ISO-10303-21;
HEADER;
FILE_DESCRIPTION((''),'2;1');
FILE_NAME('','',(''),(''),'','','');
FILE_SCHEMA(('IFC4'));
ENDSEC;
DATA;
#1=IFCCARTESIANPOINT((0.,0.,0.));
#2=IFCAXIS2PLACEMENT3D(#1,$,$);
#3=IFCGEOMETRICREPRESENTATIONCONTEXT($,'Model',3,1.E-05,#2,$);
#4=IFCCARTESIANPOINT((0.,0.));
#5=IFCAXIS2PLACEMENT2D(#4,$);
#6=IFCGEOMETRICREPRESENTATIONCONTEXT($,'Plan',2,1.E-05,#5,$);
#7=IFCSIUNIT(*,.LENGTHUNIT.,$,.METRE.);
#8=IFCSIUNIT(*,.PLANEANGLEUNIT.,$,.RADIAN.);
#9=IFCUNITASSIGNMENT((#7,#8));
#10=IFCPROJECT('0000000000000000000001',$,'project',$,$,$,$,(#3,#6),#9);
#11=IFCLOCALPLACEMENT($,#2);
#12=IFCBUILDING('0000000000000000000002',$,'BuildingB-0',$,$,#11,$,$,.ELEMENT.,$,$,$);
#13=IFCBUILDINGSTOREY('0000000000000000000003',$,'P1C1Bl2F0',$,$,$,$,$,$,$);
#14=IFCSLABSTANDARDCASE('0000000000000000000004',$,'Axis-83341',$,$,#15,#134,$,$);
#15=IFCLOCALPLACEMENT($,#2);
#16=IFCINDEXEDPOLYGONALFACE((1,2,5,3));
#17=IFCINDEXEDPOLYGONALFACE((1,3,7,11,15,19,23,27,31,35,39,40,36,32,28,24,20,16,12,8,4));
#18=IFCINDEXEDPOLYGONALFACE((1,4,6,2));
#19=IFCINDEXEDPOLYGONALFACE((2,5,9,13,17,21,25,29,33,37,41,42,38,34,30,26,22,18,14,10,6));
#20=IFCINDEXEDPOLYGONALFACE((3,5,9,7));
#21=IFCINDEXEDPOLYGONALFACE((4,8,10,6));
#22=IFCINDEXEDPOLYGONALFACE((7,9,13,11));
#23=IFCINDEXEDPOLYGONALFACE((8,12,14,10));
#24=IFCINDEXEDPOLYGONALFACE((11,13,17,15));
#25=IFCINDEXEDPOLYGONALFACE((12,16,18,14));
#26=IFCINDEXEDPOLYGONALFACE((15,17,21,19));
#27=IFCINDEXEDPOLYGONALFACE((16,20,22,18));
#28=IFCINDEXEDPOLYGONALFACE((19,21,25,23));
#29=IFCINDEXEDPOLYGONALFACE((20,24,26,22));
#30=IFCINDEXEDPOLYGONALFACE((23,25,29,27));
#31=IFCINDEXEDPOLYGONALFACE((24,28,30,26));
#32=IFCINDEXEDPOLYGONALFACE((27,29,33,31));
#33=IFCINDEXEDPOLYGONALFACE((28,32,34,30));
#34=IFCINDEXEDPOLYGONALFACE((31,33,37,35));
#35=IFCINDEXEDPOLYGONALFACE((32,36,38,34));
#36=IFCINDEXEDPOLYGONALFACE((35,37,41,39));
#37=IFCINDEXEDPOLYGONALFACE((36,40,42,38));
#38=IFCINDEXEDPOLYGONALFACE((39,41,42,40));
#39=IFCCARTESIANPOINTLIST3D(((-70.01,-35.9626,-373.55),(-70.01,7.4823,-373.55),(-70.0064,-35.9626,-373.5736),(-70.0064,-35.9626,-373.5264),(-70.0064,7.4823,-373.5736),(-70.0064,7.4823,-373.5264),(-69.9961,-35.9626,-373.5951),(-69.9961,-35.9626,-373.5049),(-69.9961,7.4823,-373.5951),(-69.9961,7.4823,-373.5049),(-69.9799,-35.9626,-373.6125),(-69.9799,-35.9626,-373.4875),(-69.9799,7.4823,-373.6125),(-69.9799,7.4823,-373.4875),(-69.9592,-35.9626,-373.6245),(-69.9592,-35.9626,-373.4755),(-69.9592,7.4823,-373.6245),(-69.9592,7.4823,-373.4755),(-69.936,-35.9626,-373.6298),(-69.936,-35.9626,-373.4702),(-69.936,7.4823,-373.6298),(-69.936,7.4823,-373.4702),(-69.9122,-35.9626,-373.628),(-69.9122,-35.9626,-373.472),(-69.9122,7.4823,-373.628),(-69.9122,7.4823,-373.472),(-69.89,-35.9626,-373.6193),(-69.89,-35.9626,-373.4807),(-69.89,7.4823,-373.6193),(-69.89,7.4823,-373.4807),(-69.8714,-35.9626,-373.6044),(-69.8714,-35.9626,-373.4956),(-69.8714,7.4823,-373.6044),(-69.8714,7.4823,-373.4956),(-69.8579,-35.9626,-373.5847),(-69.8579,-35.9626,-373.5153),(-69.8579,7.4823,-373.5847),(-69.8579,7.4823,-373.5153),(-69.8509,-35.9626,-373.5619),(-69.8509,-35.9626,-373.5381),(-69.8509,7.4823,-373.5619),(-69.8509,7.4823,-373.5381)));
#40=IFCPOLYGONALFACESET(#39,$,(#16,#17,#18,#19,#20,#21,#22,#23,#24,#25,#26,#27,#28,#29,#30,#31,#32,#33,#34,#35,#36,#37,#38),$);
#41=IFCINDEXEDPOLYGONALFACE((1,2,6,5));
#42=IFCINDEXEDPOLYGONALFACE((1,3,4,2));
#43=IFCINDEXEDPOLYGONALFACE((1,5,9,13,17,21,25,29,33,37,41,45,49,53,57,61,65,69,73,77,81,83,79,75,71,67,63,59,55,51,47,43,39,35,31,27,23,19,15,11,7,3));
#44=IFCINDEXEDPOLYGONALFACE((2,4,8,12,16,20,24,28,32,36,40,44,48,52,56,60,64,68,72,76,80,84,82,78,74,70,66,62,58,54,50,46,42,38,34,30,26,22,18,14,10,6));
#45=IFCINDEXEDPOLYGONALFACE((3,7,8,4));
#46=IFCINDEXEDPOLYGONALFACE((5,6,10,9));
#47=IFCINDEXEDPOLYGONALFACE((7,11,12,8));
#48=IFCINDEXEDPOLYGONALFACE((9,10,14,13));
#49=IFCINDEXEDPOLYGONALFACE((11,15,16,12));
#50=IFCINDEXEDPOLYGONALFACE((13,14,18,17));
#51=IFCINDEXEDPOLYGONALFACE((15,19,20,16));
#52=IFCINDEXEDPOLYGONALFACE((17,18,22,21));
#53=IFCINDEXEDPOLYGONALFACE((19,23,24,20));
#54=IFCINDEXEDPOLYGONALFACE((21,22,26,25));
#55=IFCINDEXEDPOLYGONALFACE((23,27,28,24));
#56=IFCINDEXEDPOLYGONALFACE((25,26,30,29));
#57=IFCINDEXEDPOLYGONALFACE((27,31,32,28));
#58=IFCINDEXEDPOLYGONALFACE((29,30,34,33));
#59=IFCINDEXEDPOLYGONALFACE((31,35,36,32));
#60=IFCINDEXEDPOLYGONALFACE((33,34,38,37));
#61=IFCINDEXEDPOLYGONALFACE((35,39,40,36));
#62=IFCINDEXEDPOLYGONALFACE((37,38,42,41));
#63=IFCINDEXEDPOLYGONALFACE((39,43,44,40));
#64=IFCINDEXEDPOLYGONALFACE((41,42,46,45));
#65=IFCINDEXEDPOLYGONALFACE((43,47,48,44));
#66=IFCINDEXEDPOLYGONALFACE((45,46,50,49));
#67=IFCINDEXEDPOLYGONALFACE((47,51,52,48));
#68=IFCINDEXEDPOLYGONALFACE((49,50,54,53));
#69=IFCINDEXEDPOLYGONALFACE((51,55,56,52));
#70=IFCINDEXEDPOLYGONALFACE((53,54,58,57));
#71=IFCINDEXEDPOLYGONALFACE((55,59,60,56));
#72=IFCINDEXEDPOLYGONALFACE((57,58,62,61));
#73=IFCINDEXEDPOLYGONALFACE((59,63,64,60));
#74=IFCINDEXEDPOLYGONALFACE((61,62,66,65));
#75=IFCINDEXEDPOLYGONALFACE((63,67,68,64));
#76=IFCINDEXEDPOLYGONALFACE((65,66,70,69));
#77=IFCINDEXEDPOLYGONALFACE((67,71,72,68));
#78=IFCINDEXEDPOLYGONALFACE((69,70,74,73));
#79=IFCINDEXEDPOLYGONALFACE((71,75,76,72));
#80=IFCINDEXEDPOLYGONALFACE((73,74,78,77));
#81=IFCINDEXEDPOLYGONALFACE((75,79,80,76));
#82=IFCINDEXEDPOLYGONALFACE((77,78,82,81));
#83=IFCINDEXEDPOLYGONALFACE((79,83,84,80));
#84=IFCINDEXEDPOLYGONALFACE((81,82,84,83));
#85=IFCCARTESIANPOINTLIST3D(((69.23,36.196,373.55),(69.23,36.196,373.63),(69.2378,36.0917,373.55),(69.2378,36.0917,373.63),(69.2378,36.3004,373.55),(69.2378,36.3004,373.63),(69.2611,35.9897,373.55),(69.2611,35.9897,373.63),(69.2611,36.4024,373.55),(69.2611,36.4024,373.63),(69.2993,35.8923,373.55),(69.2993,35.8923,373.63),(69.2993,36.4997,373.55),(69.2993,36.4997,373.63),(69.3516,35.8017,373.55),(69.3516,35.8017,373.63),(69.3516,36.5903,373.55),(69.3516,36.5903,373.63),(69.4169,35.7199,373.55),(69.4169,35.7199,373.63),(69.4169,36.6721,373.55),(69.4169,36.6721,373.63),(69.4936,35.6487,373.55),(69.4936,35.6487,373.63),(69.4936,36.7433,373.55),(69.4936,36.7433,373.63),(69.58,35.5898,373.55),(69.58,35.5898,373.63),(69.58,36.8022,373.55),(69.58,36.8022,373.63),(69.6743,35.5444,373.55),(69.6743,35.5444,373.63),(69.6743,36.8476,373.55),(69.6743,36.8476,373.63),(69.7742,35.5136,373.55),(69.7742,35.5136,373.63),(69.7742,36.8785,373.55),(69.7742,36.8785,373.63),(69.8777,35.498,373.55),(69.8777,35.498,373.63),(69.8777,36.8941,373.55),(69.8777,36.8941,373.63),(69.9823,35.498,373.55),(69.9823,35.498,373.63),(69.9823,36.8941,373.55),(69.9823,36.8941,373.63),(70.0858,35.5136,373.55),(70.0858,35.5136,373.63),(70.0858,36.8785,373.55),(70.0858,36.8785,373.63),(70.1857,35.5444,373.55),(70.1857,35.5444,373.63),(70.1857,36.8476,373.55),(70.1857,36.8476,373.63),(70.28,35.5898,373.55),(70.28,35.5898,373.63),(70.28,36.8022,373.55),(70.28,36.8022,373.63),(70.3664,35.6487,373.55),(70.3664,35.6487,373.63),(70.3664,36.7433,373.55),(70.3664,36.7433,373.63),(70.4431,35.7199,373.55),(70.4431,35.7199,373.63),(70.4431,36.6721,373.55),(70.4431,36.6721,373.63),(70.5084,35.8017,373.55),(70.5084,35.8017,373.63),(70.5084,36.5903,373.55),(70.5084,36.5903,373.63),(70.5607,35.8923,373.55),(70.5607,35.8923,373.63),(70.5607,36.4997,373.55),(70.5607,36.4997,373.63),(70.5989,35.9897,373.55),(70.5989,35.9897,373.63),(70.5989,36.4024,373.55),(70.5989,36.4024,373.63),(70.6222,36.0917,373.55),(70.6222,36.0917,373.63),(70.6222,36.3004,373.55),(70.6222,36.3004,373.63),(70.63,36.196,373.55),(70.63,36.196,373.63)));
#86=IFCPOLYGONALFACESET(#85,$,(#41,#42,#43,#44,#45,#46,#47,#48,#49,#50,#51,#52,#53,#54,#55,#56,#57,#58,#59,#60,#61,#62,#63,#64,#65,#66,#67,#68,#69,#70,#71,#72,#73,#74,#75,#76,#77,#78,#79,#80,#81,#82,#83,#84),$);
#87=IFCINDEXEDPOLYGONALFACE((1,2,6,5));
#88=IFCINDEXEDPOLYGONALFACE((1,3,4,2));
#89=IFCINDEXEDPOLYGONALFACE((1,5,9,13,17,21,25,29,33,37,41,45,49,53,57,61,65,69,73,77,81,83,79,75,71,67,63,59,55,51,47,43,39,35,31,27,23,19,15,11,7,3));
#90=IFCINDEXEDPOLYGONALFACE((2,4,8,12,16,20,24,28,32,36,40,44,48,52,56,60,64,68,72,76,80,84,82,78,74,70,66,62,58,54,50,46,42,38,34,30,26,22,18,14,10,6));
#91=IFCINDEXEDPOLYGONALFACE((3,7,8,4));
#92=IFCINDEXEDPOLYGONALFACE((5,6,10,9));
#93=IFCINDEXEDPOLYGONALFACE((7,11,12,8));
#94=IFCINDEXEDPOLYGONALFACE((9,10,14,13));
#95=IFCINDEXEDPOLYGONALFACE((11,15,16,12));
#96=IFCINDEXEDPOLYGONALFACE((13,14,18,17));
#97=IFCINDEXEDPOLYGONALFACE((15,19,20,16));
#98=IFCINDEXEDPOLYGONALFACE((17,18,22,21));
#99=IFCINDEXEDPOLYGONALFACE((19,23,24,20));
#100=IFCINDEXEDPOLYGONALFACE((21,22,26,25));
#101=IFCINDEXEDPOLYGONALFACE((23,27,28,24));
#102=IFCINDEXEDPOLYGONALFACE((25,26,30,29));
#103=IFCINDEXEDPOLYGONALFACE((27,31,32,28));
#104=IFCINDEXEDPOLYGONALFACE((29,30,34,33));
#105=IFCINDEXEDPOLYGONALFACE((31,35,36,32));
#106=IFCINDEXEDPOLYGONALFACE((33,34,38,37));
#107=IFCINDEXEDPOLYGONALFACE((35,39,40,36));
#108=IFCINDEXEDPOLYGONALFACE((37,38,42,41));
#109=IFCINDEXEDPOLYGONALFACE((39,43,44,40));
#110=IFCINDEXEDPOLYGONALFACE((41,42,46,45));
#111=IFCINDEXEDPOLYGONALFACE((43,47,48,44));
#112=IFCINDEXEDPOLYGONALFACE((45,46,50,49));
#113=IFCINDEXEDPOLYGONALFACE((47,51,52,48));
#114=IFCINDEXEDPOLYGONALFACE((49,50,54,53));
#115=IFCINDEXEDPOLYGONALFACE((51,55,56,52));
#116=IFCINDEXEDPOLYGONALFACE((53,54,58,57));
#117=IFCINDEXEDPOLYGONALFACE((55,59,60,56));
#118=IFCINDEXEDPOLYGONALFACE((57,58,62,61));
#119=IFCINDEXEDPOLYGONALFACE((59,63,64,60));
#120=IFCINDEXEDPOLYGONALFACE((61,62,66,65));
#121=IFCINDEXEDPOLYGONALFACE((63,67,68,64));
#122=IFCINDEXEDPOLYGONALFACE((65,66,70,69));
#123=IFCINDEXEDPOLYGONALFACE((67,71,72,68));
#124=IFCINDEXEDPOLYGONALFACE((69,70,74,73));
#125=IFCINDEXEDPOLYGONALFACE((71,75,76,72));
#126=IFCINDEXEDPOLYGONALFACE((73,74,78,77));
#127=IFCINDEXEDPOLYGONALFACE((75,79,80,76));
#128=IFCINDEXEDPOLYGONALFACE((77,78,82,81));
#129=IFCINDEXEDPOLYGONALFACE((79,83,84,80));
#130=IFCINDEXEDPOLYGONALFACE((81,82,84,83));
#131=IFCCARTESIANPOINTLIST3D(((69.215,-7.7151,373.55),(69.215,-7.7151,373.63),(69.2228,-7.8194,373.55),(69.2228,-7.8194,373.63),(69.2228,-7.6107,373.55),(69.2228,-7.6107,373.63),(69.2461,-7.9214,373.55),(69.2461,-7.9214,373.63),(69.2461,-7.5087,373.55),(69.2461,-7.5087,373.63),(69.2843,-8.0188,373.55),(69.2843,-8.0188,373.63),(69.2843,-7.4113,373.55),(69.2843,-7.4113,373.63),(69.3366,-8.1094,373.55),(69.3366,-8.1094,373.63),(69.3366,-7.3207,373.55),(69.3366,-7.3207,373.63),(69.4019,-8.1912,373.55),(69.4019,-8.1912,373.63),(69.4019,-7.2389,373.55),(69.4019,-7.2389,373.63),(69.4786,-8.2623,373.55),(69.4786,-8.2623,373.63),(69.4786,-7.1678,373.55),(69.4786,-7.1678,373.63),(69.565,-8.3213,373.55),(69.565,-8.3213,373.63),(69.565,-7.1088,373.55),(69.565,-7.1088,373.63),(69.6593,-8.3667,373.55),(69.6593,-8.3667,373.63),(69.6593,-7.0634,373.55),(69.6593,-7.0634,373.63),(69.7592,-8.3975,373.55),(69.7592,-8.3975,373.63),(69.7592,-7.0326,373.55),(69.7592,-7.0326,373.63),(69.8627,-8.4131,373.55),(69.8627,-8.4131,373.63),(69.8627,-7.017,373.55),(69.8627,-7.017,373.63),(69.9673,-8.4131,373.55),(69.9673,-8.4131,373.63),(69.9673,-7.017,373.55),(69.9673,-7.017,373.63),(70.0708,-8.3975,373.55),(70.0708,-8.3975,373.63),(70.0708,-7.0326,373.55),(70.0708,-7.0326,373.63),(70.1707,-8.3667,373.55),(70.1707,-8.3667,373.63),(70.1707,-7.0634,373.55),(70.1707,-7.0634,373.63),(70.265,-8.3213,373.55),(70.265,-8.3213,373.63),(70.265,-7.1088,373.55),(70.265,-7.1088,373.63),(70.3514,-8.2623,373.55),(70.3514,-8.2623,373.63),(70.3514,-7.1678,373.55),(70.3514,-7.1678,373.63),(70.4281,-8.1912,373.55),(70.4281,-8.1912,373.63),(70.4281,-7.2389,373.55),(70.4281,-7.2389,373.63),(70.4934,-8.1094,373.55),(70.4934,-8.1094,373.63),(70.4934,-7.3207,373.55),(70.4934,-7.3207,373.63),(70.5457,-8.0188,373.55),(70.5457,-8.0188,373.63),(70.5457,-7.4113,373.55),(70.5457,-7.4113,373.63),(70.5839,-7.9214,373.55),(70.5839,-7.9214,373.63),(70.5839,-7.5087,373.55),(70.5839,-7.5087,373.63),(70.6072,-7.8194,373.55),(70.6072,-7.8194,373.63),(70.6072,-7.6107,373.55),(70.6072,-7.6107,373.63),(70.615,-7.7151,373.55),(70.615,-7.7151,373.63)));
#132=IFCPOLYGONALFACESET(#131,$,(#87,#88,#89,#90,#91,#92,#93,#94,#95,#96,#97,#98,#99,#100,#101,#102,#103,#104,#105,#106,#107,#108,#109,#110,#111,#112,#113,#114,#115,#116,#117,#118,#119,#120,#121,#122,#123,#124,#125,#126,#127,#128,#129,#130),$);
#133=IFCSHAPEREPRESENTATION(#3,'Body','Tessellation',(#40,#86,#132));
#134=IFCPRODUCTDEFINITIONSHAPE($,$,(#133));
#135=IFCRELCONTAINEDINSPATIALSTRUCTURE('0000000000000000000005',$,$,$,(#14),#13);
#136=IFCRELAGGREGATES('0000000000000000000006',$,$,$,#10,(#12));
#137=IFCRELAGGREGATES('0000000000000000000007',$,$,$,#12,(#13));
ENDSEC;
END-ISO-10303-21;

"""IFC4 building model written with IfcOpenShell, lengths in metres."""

from ifc_helpers import new_model, entity, si_unit, frame, origin, origin_2d, place, context, project, spatial, circle, extrude, element, save


model = new_model("IFC4")

# Units and contexts
model_context = context("Model", 3, precision=1e-05, world=origin())
plan_context = context("Plan", 2, precision=1e-05, world=origin_2d())
ifc_project = project(units=[si_unit("LENGTHUNIT", "METRE"), si_unit("PLANEANGLEUNIT", "RADIAN")], contexts=[model_context, plan_context])

# Building, storey
building_placement = place(None, origin())
building = spatial("IfcBuilding", under=ifc_project, at=building_placement, Name="BuildingB-0", CompositionType="ELEMENT")
storey = spatial("IfcBuildingStorey", under=building, Name="P1C1Bl2F0")

# Slab
element("IfcSlabStandardCase", 1, inside=storey, Name="Axis-83341", context=model_context, shape_type="AdvancedSweptSolid", body=[
    entity("IfcSurfaceCurveSweptAreaSolid", entity("IfcCircleProfileDef", "AREA", None, None, 0.08), None, entity("IfcPolyline", [entity("IfcCartesianPoint", [69.93, 35.9626, 373.55]), entity("IfcCartesianPoint", [69.93, -7.4823, 373.55])]), None, None, entity("IfcPlane", entity("IfcAxis2Placement3D", entity("IfcCartesianPoint", [69.93, 35.9626, 373.55]), entity("IfcDirection", [0.0, 0.0, 1.0]), entity("IfcDirection", [1.0, 0.0, 0.0])))),
    extrude(circle(Radius=0.7), frame((69.93, 36.196, 373.55)), (0.0, 0.0, 1.0), 0.08),
    extrude(circle(Radius=0.7), frame((69.915, -7.7151, 373.55)), (0.0, 0.0, 1.0), 0.08),
])

save(model, "model.ifc")
